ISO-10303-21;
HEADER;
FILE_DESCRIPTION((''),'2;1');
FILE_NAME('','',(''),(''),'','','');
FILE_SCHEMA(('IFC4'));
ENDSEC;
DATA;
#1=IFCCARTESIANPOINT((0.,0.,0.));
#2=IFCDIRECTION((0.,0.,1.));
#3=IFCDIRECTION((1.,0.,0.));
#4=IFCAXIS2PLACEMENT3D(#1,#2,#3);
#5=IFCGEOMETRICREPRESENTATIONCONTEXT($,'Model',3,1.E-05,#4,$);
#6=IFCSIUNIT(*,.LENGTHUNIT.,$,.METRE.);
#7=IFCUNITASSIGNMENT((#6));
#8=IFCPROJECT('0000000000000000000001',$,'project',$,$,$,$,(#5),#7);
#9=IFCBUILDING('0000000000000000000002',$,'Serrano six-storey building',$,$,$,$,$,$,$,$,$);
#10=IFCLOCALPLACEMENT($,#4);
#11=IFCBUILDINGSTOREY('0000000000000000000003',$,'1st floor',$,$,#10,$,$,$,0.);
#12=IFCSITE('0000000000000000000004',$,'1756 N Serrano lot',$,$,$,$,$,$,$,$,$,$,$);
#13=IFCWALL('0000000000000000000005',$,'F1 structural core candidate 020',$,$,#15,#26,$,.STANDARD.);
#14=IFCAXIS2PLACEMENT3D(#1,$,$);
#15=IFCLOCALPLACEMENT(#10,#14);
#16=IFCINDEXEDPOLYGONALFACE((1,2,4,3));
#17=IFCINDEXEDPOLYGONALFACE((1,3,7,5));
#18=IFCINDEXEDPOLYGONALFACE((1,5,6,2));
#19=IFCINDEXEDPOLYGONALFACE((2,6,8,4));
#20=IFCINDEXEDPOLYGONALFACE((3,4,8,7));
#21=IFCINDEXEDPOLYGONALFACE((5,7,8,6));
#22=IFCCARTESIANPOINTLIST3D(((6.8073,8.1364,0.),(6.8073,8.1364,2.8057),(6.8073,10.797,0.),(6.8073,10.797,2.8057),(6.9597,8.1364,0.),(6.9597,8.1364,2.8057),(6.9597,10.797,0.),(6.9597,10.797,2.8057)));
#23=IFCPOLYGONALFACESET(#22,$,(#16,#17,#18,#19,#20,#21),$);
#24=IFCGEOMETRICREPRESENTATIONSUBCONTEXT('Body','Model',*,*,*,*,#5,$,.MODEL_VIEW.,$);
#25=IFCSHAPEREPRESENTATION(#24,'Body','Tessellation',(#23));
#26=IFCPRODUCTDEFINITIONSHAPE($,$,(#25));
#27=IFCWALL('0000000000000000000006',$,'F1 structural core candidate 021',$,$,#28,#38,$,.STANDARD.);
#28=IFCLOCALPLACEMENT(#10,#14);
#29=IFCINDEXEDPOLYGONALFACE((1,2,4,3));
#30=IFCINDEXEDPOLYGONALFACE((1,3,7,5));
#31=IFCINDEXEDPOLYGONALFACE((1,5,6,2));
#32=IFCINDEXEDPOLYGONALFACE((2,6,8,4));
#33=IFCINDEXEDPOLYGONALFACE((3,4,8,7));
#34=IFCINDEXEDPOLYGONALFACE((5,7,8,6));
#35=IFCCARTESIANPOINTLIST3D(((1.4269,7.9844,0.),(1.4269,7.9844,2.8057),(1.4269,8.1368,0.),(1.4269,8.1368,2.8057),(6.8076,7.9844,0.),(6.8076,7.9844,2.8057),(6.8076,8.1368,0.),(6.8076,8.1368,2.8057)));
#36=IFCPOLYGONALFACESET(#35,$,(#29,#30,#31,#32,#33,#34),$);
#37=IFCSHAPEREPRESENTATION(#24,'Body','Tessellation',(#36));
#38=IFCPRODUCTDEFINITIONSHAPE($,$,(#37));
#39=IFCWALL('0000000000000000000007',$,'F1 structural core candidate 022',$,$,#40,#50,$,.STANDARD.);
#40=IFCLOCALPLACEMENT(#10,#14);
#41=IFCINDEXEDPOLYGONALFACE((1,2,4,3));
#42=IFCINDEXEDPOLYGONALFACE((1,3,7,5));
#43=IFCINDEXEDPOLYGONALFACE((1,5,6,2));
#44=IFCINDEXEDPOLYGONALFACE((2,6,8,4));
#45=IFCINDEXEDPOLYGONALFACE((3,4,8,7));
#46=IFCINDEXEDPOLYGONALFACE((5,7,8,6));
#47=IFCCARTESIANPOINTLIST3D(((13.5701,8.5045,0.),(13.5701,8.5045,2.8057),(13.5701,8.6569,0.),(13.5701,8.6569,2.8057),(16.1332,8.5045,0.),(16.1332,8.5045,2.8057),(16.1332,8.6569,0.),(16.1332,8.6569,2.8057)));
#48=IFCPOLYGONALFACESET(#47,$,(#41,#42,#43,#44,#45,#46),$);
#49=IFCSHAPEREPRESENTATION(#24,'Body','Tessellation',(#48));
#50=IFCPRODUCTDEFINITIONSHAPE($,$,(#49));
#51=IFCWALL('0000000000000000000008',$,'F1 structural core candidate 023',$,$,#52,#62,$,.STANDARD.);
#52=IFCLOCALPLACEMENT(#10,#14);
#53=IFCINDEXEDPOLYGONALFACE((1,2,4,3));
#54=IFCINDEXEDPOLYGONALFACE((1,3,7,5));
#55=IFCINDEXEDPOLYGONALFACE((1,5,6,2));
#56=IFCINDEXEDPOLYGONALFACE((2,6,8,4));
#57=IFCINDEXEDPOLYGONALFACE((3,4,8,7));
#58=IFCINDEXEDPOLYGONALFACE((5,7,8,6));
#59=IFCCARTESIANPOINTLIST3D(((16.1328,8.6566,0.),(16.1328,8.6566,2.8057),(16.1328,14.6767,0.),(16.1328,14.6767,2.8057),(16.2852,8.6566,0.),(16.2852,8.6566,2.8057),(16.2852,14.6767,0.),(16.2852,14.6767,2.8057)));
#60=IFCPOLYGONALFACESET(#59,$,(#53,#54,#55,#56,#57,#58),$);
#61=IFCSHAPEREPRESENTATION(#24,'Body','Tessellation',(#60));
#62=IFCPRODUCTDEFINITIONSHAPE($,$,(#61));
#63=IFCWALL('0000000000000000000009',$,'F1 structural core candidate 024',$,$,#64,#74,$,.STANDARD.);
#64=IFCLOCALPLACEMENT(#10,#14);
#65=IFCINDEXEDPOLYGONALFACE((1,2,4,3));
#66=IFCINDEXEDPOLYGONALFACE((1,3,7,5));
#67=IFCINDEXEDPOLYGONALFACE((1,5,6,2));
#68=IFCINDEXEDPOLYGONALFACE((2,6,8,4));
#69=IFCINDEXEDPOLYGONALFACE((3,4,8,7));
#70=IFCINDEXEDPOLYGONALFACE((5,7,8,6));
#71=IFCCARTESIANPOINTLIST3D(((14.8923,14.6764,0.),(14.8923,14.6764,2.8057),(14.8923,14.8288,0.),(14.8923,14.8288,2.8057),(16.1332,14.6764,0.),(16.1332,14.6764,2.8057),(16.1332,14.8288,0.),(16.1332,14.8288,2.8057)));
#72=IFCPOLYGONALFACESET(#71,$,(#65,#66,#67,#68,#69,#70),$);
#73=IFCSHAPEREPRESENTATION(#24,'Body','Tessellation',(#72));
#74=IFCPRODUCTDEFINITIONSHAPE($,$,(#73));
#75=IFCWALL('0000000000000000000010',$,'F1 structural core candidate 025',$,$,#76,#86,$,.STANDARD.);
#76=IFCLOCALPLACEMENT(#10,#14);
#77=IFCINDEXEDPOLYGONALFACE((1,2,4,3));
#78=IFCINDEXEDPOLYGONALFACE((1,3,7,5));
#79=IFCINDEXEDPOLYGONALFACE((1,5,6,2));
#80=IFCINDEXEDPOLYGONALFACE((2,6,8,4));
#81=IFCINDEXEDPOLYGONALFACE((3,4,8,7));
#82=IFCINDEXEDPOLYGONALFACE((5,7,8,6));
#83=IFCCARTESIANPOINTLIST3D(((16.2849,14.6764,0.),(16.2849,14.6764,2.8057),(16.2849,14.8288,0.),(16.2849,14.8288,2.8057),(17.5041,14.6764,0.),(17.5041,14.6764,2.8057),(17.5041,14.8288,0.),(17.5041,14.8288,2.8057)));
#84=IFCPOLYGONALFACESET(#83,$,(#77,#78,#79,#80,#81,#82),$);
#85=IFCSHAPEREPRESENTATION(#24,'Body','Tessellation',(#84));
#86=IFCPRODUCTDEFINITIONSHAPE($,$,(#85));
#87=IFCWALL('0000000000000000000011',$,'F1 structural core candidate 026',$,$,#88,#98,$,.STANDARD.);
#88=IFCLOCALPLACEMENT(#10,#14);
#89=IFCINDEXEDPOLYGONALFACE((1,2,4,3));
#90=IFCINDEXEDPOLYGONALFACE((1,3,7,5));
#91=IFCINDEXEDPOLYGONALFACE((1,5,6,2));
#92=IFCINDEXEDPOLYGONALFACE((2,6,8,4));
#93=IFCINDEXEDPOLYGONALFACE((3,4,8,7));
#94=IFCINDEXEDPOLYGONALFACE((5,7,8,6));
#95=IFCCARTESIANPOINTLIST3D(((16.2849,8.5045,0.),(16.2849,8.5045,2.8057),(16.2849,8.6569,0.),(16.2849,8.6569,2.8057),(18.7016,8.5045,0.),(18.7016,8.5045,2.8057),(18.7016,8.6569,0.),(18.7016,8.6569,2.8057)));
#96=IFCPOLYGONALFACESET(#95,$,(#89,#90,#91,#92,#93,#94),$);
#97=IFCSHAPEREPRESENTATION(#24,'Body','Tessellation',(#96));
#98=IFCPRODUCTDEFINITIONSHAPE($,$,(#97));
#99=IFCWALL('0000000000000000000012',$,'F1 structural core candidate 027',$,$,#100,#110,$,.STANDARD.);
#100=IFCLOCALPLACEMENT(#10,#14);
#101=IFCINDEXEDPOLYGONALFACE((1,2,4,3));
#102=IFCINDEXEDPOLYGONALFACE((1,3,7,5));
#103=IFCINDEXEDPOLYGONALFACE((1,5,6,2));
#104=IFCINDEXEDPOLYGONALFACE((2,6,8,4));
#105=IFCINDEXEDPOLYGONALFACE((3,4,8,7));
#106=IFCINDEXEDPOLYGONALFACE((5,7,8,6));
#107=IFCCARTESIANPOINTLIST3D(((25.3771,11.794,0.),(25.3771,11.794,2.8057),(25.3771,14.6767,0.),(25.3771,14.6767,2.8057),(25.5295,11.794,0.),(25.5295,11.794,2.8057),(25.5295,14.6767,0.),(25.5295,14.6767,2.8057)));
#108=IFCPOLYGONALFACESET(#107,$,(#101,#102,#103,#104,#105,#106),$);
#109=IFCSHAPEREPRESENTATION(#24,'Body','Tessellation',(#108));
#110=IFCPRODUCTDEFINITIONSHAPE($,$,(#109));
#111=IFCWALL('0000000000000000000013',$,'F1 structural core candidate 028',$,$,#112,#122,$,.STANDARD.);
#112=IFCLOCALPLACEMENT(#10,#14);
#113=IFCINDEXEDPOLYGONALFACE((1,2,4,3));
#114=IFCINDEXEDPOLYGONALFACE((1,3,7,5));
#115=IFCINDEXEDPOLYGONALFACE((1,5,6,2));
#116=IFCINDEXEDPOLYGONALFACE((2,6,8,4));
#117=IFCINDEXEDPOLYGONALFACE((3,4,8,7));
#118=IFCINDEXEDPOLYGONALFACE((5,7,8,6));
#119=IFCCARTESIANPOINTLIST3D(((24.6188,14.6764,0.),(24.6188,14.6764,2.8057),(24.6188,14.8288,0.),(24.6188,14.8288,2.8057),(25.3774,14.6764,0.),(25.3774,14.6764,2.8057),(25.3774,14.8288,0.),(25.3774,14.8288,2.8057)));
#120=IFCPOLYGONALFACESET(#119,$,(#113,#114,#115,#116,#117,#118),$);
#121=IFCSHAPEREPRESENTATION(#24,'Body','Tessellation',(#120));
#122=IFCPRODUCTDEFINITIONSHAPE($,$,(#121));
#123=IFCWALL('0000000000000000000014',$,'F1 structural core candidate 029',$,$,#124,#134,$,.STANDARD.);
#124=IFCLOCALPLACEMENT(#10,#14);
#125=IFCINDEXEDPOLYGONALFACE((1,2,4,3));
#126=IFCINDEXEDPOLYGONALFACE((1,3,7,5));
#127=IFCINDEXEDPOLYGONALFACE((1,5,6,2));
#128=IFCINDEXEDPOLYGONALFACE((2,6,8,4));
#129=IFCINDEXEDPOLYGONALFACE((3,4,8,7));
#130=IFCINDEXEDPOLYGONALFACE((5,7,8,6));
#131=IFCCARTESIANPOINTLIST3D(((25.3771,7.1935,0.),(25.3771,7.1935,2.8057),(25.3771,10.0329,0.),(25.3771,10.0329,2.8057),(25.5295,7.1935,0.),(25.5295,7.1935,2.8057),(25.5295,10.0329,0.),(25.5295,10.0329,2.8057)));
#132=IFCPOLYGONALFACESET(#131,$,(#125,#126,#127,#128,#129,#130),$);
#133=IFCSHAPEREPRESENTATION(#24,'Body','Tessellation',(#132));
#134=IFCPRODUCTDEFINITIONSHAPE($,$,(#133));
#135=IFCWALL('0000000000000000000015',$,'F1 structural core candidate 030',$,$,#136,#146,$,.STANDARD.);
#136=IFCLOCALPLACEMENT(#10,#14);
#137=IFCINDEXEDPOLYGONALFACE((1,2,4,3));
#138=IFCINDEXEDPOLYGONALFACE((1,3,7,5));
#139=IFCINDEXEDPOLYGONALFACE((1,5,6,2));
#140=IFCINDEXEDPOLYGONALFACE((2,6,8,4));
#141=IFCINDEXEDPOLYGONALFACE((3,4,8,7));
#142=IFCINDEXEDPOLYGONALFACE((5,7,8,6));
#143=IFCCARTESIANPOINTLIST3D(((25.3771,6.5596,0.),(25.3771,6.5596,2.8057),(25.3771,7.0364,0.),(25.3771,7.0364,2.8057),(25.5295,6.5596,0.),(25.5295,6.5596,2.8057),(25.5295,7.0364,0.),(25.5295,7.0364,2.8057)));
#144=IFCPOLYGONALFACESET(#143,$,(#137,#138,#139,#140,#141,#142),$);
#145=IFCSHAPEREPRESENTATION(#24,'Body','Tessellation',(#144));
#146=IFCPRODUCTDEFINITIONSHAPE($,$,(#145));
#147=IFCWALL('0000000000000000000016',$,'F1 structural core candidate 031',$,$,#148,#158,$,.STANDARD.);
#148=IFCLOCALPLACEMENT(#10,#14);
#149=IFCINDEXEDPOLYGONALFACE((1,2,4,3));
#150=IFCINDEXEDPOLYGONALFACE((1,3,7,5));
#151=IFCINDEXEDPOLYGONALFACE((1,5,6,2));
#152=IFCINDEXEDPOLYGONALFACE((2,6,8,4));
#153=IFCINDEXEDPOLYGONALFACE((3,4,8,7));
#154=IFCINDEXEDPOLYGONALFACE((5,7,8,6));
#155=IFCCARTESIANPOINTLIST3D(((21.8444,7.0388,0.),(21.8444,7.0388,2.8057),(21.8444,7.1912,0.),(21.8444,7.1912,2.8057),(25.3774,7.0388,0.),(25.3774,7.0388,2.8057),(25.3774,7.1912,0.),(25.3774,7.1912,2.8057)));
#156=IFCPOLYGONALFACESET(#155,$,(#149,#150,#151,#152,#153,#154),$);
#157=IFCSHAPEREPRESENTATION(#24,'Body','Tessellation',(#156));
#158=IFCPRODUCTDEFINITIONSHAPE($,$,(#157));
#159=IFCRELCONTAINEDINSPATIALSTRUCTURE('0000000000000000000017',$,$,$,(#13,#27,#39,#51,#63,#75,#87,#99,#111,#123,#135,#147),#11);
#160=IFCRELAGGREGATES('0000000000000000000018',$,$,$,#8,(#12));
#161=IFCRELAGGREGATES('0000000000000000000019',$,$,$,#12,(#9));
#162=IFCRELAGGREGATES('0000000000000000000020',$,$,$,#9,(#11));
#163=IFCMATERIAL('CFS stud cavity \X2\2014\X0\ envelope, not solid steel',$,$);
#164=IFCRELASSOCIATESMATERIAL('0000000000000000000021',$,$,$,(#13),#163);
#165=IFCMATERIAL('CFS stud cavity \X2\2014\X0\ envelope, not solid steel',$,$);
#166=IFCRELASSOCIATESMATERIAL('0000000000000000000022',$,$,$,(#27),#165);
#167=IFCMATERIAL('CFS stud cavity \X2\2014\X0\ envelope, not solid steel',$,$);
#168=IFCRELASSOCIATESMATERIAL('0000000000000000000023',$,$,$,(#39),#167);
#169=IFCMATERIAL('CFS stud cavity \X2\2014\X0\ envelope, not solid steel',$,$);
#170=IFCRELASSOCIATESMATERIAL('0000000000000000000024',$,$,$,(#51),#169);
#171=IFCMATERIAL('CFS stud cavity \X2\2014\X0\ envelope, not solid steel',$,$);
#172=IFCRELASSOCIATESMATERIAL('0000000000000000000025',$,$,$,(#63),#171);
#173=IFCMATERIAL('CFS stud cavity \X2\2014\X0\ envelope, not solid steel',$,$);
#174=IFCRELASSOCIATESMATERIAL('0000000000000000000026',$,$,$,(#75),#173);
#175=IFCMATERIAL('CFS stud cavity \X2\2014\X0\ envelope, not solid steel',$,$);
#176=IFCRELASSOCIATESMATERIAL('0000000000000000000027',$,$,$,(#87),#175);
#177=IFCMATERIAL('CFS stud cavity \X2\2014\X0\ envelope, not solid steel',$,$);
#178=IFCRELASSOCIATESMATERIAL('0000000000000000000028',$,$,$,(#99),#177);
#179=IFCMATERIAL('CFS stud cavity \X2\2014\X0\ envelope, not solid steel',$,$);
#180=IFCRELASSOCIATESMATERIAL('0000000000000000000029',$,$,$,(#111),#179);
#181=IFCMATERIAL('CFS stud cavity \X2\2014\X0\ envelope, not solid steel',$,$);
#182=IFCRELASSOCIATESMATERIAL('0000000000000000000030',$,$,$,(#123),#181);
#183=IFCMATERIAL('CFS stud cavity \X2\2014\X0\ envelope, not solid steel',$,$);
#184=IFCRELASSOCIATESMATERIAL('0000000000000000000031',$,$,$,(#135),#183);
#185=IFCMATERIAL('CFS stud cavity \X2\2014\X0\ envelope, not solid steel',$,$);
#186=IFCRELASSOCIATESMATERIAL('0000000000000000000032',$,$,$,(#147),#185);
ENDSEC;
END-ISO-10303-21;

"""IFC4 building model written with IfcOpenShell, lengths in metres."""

from ifc_helpers import new_model, si_unit, origin, origin_with_axes, place, context, subcontext, project, spatial, polyline, outline, extrude, material, element, save


model = new_model("IFC4")

# Units and contexts
model_context = context("Model", 3, precision=1e-05, world=origin_with_axes())
body_context = subcontext(model_context, "Body", "Model", "MODEL_VIEW")
ifc_project = project(units=[si_unit("LENGTHUNIT", "METRE")], contexts=[model_context])

# Site, building, storey
site = spatial("IfcSite", under=ifc_project, Name="1756 N Serrano lot")
building = spatial("IfcBuilding", under=site, Name="Serrano six-storey building")
storey_placement = place(None, origin_with_axes())
storey = spatial("IfcBuildingStorey", under=building, at=storey_placement, Name="1st floor", Elevation=0.0)

# Walls
ifc_material_1 = material(Name="CFS stud cavity — envelope, not solid steel")
wall_1_placement = place(storey_placement, origin_with_axes())
element("IfcWall", 1, at=wall_1_placement, inside=storey, material=ifc_material_1, Name="F1 structural core candidate 020", PredefinedType="STANDARD", context=body_context, shape_type="SweptSolid", body=[
    extrude(outline(polyline([(6.9597, 8.1364), (6.8073, 8.1364), (6.8073, 10.797), (6.9597, 10.797), (6.9597, 8.1364)])), origin(), (0.0, 0.0, 1.0), 2.8057),
])
ifc_material_2 = material(Name="CFS stud cavity — envelope, not solid steel")
wall_2_placement = place(storey_placement, origin_with_axes())
element("IfcWall", 2, at=wall_2_placement, inside=storey, material=ifc_material_2, Name="F1 structural core candidate 021", PredefinedType="STANDARD", context=body_context, shape_type="SweptSolid", body=[
    extrude(outline(polyline([(6.8076, 8.1368), (6.8076, 7.9844), (1.4269, 7.9844), (1.4269, 8.1368), (6.8076, 8.1368)])), origin(), (0.0, 0.0, 1.0), 2.8057),
])
ifc_material_3 = material(Name="CFS stud cavity — envelope, not solid steel")
wall_3_placement = place(storey_placement, origin_with_axes())
element("IfcWall", 3, at=wall_3_placement, inside=storey, material=ifc_material_3, Name="F1 structural core candidate 022", PredefinedType="STANDARD", context=body_context, shape_type="SweptSolid", body=[
    extrude(outline(polyline([(16.1332, 8.6569), (16.1332, 8.5045), (13.5701, 8.5045), (13.5701, 8.6569), (16.1332, 8.6569)])), origin(), (0.0, 0.0, 1.0), 2.8057),
])
ifc_material_4 = material(Name="CFS stud cavity — envelope, not solid steel")
wall_4_placement = place(storey_placement, origin_with_axes())
element("IfcWall", 4, at=wall_4_placement, inside=storey, material=ifc_material_4, Name="F1 structural core candidate 023", PredefinedType="STANDARD", context=body_context, shape_type="SweptSolid", body=[
    extrude(outline(polyline([(16.2852, 8.6566), (16.1328, 8.6566), (16.1328, 14.6767), (16.2852, 14.6767), (16.2852, 8.6566)])), origin(), (0.0, 0.0, 1.0), 2.8057),
])
ifc_material_5 = material(Name="CFS stud cavity — envelope, not solid steel")
wall_5_placement = place(storey_placement, origin_with_axes())
element("IfcWall", 5, at=wall_5_placement, inside=storey, material=ifc_material_5, Name="F1 structural core candidate 024", PredefinedType="STANDARD", context=body_context, shape_type="SweptSolid", body=[
    extrude(outline(polyline([(16.1332, 14.8288), (16.1332, 14.6764), (14.8923, 14.6764), (14.8923, 14.8288), (16.1332, 14.8288)])), origin(), (0.0, 0.0, 1.0), 2.8057),
])
ifc_material_6 = material(Name="CFS stud cavity — envelope, not solid steel")
wall_6_placement = place(storey_placement, origin_with_axes())
element("IfcWall", 6, at=wall_6_placement, inside=storey, material=ifc_material_6, Name="F1 structural core candidate 025", PredefinedType="STANDARD", context=body_context, shape_type="SweptSolid", body=[
    extrude(outline(polyline([(17.5041, 14.8288), (17.5041, 14.6764), (16.2849, 14.6764), (16.2849, 14.8288), (17.5041, 14.8288)])), origin(), (0.0, 0.0, 1.0), 2.8057),
])
ifc_material_7 = material(Name="CFS stud cavity — envelope, not solid steel")
wall_7_placement = place(storey_placement, origin_with_axes())
element("IfcWall", 7, at=wall_7_placement, inside=storey, material=ifc_material_7, Name="F1 structural core candidate 026", PredefinedType="STANDARD", context=body_context, shape_type="SweptSolid", body=[
    extrude(outline(polyline([(18.7016, 8.6569), (18.7016, 8.5045), (16.2849, 8.5045), (16.2849, 8.6569), (18.7016, 8.6569)])), origin(), (0.0, 0.0, 1.0), 2.8057),
])
ifc_material_8 = material(Name="CFS stud cavity — envelope, not solid steel")
wall_8_placement = place(storey_placement, origin_with_axes())
element("IfcWall", 8, at=wall_8_placement, inside=storey, material=ifc_material_8, Name="F1 structural core candidate 027", PredefinedType="STANDARD", context=body_context, shape_type="SweptSolid", body=[
    extrude(outline(polyline([(25.5295, 11.794), (25.3771, 11.794), (25.3771, 14.6767), (25.5295, 14.6767), (25.5295, 11.794)])), origin(), (0.0, 0.0, 1.0), 2.8057),
])
ifc_material_9 = material(Name="CFS stud cavity — envelope, not solid steel")
wall_9_placement = place(storey_placement, origin_with_axes())
element("IfcWall", 9, at=wall_9_placement, inside=storey, material=ifc_material_9, Name="F1 structural core candidate 028", PredefinedType="STANDARD", context=body_context, shape_type="SweptSolid", body=[
    extrude(outline(polyline([(25.3774, 14.8288), (25.3774, 14.6764), (24.6188, 14.6764), (24.6188, 14.8288), (25.3774, 14.8288)])), origin(), (0.0, 0.0, 1.0), 2.8057),
])
ifc_material_10 = material(Name="CFS stud cavity — envelope, not solid steel")
wall_10_placement = place(storey_placement, origin_with_axes())
element("IfcWall", 10, at=wall_10_placement, inside=storey, material=ifc_material_10, Name="F1 structural core candidate 029", PredefinedType="STANDARD", context=body_context, shape_type="SweptSolid", body=[
    extrude(outline(polyline([(25.5295, 7.1935), (25.3771, 7.1935), (25.3771, 10.0329), (25.5295, 10.0329), (25.5295, 7.1935)])), origin(), (0.0, 0.0, 1.0), 2.8057),
])
ifc_material_11 = material(Name="CFS stud cavity — envelope, not solid steel")
wall_11_placement = place(storey_placement, origin_with_axes())
element("IfcWall", 11, at=wall_11_placement, inside=storey, material=ifc_material_11, Name="F1 structural core candidate 030", PredefinedType="STANDARD", context=body_context, shape_type="SweptSolid", body=[
    extrude(outline(polyline([(25.5295, 6.5596), (25.3771, 6.5596), (25.3771, 7.0364), (25.5295, 7.0364), (25.5295, 6.5596)])), origin(), (0.0, 0.0, 1.0), 2.8057),
])
ifc_material_12 = material(Name="CFS stud cavity — envelope, not solid steel")
wall_12_placement = place(storey_placement, origin_with_axes())
element("IfcWall", 12, at=wall_12_placement, inside=storey, material=ifc_material_12, Name="F1 structural core candidate 031", PredefinedType="STANDARD", context=body_context, shape_type="SweptSolid", body=[
    extrude(outline(polyline([(25.3774, 7.1912), (25.3774, 7.0388), (21.8444, 7.0388), (21.8444, 7.1912), (25.3774, 7.1912)])), origin(), (0.0, 0.0, 1.0), 2.8057),
])

save(model, "model.ifc")
